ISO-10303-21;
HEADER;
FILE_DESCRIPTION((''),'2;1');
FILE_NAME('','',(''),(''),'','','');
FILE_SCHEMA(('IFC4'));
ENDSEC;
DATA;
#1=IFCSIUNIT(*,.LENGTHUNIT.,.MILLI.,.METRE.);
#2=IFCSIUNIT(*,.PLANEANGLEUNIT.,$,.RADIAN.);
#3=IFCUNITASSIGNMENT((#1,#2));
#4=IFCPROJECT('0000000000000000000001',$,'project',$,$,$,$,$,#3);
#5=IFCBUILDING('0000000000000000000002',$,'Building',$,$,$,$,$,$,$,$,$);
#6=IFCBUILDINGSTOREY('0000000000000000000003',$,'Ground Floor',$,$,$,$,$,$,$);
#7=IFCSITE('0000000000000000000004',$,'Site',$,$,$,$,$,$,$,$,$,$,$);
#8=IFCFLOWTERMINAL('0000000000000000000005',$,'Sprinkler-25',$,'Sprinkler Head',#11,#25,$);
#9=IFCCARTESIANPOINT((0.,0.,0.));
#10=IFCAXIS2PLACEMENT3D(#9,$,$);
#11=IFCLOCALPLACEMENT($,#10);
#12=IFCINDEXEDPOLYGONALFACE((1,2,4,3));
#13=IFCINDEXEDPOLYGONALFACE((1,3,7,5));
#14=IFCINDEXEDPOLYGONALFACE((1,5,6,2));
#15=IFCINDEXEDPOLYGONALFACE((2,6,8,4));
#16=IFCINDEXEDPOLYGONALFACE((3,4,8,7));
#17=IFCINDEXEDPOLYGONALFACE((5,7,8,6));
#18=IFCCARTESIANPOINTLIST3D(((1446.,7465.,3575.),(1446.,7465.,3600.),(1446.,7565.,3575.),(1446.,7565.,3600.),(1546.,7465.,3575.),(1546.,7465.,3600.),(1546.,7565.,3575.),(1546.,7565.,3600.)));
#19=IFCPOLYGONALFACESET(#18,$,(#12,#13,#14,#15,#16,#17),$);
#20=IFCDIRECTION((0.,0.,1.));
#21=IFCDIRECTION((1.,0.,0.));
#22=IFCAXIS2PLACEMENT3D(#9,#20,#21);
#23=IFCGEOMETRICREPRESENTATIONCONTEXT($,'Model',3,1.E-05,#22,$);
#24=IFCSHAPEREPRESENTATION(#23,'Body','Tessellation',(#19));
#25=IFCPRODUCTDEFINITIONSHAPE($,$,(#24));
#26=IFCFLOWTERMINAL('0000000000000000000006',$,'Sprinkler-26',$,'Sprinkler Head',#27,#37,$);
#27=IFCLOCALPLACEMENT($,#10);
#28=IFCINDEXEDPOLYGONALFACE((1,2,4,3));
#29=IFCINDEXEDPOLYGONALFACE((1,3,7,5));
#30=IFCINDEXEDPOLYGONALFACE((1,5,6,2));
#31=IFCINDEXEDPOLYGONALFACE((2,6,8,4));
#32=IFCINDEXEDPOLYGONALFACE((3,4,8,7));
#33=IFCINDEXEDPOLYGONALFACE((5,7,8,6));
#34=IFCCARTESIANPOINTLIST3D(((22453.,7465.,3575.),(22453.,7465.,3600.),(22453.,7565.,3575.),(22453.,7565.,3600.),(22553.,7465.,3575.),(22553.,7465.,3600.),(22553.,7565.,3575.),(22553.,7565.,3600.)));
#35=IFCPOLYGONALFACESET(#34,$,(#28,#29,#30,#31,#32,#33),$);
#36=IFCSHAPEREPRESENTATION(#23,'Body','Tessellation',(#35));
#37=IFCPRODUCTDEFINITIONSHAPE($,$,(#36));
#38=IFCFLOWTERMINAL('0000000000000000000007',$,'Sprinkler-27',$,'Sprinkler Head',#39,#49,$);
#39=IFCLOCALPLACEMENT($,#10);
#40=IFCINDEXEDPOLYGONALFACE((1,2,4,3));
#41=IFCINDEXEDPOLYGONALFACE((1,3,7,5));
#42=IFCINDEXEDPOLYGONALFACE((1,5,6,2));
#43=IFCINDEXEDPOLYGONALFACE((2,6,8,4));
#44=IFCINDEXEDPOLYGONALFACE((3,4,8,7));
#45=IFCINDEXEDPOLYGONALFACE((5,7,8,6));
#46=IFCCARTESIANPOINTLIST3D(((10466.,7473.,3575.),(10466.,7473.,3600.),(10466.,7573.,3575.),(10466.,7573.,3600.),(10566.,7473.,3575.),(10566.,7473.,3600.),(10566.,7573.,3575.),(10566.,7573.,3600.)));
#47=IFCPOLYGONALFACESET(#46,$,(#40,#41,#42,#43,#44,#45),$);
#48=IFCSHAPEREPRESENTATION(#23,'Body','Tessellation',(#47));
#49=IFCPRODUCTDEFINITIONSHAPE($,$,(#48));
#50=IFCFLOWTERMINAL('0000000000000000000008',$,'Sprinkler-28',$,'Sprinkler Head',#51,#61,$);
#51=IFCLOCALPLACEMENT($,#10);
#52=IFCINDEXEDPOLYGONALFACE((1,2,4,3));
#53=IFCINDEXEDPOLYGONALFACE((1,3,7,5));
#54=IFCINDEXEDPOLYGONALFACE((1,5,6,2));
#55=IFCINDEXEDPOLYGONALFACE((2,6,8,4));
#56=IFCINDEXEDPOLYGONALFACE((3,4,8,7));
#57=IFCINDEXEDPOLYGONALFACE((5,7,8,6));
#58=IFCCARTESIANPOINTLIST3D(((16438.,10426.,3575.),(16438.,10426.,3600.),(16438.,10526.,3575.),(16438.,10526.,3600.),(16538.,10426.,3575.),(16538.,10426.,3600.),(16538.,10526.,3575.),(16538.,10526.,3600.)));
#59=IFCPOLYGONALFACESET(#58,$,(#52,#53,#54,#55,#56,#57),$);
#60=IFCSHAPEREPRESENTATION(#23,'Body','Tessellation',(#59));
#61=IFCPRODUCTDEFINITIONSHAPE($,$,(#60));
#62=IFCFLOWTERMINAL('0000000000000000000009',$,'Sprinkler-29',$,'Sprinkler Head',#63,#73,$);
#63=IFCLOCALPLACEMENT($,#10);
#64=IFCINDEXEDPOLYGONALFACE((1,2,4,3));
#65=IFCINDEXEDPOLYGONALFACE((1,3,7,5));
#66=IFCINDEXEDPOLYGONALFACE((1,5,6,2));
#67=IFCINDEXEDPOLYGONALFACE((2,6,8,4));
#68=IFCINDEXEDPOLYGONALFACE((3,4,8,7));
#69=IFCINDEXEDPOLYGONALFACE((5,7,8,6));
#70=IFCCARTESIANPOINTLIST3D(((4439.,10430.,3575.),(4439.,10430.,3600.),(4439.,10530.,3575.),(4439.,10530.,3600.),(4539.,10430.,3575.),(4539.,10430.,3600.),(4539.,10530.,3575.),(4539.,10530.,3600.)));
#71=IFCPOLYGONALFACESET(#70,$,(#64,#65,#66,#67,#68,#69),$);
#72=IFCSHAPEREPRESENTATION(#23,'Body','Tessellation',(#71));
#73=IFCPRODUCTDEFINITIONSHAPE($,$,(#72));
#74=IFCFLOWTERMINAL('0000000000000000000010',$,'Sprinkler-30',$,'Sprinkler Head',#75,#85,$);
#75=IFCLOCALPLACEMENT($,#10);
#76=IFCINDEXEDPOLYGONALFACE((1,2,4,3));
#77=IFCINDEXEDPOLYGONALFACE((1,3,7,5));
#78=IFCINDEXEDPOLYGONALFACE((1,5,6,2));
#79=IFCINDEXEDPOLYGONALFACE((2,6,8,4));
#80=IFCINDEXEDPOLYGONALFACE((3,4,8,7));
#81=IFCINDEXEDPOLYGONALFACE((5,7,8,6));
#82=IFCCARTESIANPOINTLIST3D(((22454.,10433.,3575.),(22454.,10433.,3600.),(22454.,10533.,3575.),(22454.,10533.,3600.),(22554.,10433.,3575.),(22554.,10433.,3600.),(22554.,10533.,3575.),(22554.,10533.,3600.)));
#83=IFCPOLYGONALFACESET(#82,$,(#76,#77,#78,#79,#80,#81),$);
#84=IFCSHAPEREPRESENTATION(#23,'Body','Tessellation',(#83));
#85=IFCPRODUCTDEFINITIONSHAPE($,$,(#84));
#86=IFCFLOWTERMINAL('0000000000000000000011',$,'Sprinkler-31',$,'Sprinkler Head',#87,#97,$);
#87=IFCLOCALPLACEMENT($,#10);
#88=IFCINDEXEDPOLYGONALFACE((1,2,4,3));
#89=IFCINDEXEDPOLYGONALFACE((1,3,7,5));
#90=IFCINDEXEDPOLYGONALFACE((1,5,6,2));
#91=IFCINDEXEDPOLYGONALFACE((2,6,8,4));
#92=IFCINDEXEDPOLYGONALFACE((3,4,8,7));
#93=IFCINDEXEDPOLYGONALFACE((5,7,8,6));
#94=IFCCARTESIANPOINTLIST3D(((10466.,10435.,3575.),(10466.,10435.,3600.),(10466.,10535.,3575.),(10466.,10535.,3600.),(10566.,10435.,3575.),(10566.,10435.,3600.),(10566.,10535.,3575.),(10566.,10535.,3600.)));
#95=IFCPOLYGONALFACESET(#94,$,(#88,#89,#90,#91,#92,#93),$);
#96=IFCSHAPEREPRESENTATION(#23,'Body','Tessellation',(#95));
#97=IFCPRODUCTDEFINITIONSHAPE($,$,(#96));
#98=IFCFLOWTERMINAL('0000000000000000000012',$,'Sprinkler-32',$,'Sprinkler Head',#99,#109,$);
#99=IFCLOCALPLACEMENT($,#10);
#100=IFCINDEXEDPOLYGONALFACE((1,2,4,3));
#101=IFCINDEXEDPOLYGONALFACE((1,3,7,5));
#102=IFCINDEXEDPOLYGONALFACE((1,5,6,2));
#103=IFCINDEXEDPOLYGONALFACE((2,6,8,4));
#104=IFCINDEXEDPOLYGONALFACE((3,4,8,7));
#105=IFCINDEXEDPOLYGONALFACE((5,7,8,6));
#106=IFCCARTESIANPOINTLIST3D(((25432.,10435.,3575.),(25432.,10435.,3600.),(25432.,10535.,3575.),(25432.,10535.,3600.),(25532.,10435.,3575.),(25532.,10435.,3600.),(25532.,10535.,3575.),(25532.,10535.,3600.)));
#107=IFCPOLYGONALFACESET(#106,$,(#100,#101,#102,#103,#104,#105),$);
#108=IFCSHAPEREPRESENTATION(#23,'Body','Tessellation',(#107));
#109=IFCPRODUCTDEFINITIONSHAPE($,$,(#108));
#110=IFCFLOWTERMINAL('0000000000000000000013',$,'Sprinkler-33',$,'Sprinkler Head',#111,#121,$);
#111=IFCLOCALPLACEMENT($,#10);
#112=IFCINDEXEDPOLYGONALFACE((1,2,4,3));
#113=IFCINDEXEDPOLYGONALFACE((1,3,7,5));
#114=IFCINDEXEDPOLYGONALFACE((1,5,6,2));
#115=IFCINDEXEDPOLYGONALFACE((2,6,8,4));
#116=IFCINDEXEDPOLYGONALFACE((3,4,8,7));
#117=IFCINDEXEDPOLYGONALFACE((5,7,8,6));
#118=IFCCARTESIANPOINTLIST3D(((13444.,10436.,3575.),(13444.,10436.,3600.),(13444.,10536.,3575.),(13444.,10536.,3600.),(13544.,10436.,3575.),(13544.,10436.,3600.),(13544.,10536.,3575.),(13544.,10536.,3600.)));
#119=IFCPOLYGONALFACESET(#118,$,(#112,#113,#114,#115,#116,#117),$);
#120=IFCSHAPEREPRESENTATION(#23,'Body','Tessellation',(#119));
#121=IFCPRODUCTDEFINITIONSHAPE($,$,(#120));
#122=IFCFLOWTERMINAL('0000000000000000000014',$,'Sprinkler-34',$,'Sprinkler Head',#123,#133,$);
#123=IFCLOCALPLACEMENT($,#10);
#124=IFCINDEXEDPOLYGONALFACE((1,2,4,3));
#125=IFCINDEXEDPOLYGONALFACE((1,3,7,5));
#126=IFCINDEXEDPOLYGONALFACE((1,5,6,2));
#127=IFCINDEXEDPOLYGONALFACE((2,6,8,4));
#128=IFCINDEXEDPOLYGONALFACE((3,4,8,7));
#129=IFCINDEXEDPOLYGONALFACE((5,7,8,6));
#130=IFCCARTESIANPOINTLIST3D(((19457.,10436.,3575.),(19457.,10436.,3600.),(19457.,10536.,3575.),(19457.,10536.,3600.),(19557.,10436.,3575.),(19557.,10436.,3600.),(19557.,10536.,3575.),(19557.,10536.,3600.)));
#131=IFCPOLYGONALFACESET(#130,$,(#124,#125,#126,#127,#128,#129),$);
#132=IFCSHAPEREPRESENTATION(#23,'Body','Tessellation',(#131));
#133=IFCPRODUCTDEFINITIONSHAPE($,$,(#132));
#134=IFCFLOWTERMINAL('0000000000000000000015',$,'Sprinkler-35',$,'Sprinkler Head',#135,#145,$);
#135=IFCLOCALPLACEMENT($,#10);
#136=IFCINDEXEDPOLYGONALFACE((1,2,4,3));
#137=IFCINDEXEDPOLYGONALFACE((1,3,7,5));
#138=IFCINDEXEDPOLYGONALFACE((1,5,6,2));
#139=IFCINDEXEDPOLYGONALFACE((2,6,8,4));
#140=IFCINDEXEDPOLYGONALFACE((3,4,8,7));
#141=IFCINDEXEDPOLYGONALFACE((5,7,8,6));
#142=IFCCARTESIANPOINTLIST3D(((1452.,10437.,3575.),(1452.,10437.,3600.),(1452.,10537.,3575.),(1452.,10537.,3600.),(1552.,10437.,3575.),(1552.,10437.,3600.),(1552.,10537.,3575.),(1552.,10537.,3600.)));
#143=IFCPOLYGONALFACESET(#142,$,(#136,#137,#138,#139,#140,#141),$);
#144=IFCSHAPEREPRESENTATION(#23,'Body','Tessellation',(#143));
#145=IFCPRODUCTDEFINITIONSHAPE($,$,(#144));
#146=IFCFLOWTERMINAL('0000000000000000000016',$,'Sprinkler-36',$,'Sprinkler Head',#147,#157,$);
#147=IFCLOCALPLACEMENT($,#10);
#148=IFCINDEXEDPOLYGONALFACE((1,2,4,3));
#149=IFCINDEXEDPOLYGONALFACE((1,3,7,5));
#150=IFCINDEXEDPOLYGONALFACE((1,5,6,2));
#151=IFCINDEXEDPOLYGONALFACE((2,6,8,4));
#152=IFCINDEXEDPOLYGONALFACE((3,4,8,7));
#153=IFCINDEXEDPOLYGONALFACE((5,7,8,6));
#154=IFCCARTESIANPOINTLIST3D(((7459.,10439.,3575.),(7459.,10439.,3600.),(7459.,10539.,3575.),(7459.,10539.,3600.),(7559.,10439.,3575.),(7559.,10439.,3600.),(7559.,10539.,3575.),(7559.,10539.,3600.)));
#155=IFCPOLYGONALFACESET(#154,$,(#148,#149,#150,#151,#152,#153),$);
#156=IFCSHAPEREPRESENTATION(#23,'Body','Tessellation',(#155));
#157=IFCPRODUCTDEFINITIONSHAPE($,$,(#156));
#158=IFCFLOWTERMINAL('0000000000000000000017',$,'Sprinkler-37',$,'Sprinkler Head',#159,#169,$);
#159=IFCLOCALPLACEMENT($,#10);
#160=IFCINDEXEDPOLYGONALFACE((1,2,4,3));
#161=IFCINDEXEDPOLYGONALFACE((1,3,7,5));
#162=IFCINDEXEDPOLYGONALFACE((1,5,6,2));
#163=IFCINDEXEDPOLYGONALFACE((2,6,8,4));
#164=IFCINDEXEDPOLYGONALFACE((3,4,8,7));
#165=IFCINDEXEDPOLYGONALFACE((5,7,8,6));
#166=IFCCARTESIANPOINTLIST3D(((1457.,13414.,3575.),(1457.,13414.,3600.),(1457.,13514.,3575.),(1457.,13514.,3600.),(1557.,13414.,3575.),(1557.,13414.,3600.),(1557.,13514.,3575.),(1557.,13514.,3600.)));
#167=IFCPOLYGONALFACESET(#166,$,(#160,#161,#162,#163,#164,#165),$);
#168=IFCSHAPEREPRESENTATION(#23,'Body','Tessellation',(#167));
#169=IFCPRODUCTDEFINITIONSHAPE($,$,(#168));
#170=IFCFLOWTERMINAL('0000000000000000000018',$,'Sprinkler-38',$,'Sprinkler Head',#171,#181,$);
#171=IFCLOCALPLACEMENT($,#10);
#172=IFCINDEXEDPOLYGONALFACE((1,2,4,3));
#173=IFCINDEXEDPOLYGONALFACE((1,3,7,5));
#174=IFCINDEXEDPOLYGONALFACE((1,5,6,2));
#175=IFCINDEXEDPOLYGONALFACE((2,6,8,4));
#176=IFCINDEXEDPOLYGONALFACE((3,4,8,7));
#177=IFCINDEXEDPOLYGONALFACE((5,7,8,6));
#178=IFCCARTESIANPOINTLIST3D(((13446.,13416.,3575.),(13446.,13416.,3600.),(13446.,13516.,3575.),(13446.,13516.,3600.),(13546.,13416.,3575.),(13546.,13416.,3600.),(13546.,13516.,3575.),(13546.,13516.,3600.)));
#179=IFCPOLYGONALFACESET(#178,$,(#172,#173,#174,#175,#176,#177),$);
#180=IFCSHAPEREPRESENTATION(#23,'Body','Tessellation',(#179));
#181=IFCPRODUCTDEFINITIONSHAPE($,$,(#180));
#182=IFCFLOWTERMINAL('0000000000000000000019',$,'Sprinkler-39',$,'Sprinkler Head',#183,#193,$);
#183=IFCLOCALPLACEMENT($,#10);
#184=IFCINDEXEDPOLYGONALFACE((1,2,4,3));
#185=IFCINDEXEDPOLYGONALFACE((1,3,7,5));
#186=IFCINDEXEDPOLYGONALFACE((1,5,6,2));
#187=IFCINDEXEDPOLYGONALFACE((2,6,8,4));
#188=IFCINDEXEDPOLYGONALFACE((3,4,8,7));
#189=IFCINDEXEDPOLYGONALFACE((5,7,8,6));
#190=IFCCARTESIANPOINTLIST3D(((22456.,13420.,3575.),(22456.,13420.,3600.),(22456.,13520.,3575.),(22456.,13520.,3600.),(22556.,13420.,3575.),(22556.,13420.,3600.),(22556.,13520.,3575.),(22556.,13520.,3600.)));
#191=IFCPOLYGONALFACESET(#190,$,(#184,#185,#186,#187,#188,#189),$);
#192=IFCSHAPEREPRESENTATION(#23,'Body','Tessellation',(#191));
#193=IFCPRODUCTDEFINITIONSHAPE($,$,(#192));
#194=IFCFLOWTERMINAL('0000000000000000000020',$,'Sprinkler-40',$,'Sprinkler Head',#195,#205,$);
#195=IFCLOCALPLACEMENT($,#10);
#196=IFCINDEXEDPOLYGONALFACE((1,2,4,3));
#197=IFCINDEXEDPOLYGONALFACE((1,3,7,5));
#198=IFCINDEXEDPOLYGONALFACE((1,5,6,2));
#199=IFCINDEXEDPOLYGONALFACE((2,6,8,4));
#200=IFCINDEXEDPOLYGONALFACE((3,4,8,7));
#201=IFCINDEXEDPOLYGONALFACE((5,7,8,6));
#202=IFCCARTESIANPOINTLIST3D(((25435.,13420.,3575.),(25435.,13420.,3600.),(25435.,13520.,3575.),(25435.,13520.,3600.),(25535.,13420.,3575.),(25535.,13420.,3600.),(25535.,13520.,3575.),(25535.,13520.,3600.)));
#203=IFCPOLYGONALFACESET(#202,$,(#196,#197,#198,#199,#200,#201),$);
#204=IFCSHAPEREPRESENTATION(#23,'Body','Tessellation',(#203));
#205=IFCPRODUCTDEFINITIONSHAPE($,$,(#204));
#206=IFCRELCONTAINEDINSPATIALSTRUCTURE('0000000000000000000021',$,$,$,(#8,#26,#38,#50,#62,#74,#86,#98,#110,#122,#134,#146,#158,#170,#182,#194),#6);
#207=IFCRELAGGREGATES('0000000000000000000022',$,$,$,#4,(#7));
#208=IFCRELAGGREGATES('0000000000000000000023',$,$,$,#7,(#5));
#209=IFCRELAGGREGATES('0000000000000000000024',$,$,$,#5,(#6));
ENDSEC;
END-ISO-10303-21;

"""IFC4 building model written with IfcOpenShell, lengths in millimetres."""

from ifc_helpers import new_model, si_unit, frame, origin_with_axes, place, context, project, spatial, rectangle, extrude, element, save


model = new_model("IFC4")

# Units and contexts
model_context = context("Model", 3, precision=1e-05, world=origin_with_axes())
ifc_project = project(units=[si_unit("LENGTHUNIT", "METRE", prefix="MILLI"), si_unit("PLANEANGLEUNIT", "RADIAN")])

# Site, building, storey
site = spatial("IfcSite", under=ifc_project, Name="Site")
building = spatial("IfcBuilding", under=site, Name="Building")
storey = spatial("IfcBuildingStorey", under=building, Name="Ground Floor")

# Flow terminals
flow_terminal_1_placement = place(None, origin_with_axes())
element("IfcFlowTerminal", 1, at=flow_terminal_1_placement, inside=storey, Name="Sprinkler-25", ObjectType="Sprinkler Head", context=model_context, shape_type="SweptSolid", body=[
    extrude(rectangle(XDim=100.0, YDim=100.0), frame((1496.0, 7515.0, 3575.0), z_axis=(0.0, 0.0, 1.0), x_axis=(1.0, 0.0, 0.0)), (0.0, 0.0, 1.0), 25.0),
])
flow_terminal_2_placement = place(None, origin_with_axes())
element("IfcFlowTerminal", 2, at=flow_terminal_2_placement, inside=storey, Name="Sprinkler-26", ObjectType="Sprinkler Head", context=model_context, shape_type="SweptSolid", body=[
    extrude(rectangle(XDim=100.0, YDim=100.0), frame((22503.0, 7515.0, 3575.0), z_axis=(0.0, 0.0, 1.0), x_axis=(1.0, 0.0, 0.0)), (0.0, 0.0, 1.0), 25.0),
])
flow_terminal_3_placement = place(None, origin_with_axes())
element("IfcFlowTerminal", 3, at=flow_terminal_3_placement, inside=storey, Name="Sprinkler-27", ObjectType="Sprinkler Head", context=model_context, shape_type="SweptSolid", body=[
    extrude(rectangle(XDim=100.0, YDim=100.0), frame((10516.0, 7523.0, 3575.0), z_axis=(0.0, 0.0, 1.0), x_axis=(1.0, 0.0, 0.0)), (0.0, 0.0, 1.0), 25.0),
])
flow_terminal_4_placement = place(None, origin_with_axes())
element("IfcFlowTerminal", 4, at=flow_terminal_4_placement, inside=storey, Name="Sprinkler-28", ObjectType="Sprinkler Head", context=model_context, shape_type="SweptSolid", body=[
    extrude(rectangle(XDim=100.0, YDim=100.0), frame((16488.0, 10476.0, 3575.0), z_axis=(0.0, 0.0, 1.0), x_axis=(1.0, 0.0, 0.0)), (0.0, 0.0, 1.0), 25.0),
])
flow_terminal_5_placement = place(None, origin_with_axes())
element("IfcFlowTerminal", 5, at=flow_terminal_5_placement, inside=storey, Name="Sprinkler-29", ObjectType="Sprinkler Head", context=model_context, shape_type="SweptSolid", body=[
    extrude(rectangle(XDim=100.0, YDim=100.0), frame((4489.0, 10480.0, 3575.0), z_axis=(0.0, 0.0, 1.0), x_axis=(1.0, 0.0, 0.0)), (0.0, 0.0, 1.0), 25.0),
])
flow_terminal_6_placement = place(None, origin_with_axes())
element("IfcFlowTerminal", 6, at=flow_terminal_6_placement, inside=storey, Name="Sprinkler-30", ObjectType="Sprinkler Head", context=model_context, shape_type="SweptSolid", body=[
    extrude(rectangle(XDim=100.0, YDim=100.0), frame((22504.0, 10483.0, 3575.0), z_axis=(0.0, 0.0, 1.0), x_axis=(1.0, 0.0, 0.0)), (0.0, 0.0, 1.0), 25.0),
])
flow_terminal_7_placement = place(None, origin_with_axes())
element("IfcFlowTerminal", 7, at=flow_terminal_7_placement, inside=storey, Name="Sprinkler-31", ObjectType="Sprinkler Head", context=model_context, shape_type="SweptSolid", body=[
    extrude(rectangle(XDim=100.0, YDim=100.0), frame((10516.0, 10485.0, 3575.0), z_axis=(0.0, 0.0, 1.0), x_axis=(1.0, 0.0, 0.0)), (0.0, 0.0, 1.0), 25.0),
])
flow_terminal_8_placement = place(None, origin_with_axes())
element("IfcFlowTerminal", 8, at=flow_terminal_8_placement, inside=storey, Name="Sprinkler-32", ObjectType="Sprinkler Head", context=model_context, shape_type="SweptSolid", body=[
    extrude(rectangle(XDim=100.0, YDim=100.0), frame((25482.0, 10485.0, 3575.0), z_axis=(0.0, 0.0, 1.0), x_axis=(1.0, 0.0, 0.0)), (0.0, 0.0, 1.0), 25.0),
])
flow_terminal_9_placement = place(None, origin_with_axes())
element("IfcFlowTerminal", 9, at=flow_terminal_9_placement, inside=storey, Name="Sprinkler-33", ObjectType="Sprinkler Head", context=model_context, shape_type="SweptSolid", body=[
    extrude(rectangle(XDim=100.0, YDim=100.0), frame((13494.0, 10486.0, 3575.0), z_axis=(0.0, 0.0, 1.0), x_axis=(1.0, 0.0, 0.0)), (0.0, 0.0, 1.0), 25.0),
])
flow_terminal_10_placement = place(None, origin_with_axes())
element("IfcFlowTerminal", 10, at=flow_terminal_10_placement, inside=storey, Name="Sprinkler-34", ObjectType="Sprinkler Head", context=model_context, shape_type="SweptSolid", body=[
    extrude(rectangle(XDim=100.0, YDim=100.0), frame((19507.0, 10486.0, 3575.0), z_axis=(0.0, 0.0, 1.0), x_axis=(1.0, 0.0, 0.0)), (0.0, 0.0, 1.0), 25.0),
])
flow_terminal_11_placement = place(None, origin_with_axes())
element("IfcFlowTerminal", 11, at=flow_terminal_11_placement, inside=storey, Name="Sprinkler-35", ObjectType="Sprinkler Head", context=model_context, shape_type="SweptSolid", body=[
    extrude(rectangle(XDim=100.0, YDim=100.0), frame((1502.0, 10487.0, 3575.0), z_axis=(0.0, 0.0, 1.0), x_axis=(1.0, 0.0, 0.0)), (0.0, 0.0, 1.0), 25.0),
])
flow_terminal_12_placement = place(None, origin_with_axes())
element("IfcFlowTerminal", 12, at=flow_terminal_12_placement, inside=storey, Name="Sprinkler-36", ObjectType="Sprinkler Head", context=model_context, shape_type="SweptSolid", body=[
    extrude(rectangle(XDim=100.0, YDim=100.0), frame((7509.0, 10489.0, 3575.0), z_axis=(0.0, 0.0, 1.0), x_axis=(1.0, 0.0, 0.0)), (0.0, 0.0, 1.0), 25.0),
])
flow_terminal_13_placement = place(None, origin_with_axes())
element("IfcFlowTerminal", 13, at=flow_terminal_13_placement, inside=storey, Name="Sprinkler-37", ObjectType="Sprinkler Head", context=model_context, shape_type="SweptSolid", body=[
    extrude(rectangle(XDim=100.0, YDim=100.0), frame((1507.0, 13464.0, 3575.0), z_axis=(0.0, 0.0, 1.0), x_axis=(1.0, 0.0, 0.0)), (0.0, 0.0, 1.0), 25.0),
])
flow_terminal_14_placement = place(None, origin_with_axes())
element("IfcFlowTerminal", 14, at=flow_terminal_14_placement, inside=storey, Name="Sprinkler-38", ObjectType="Sprinkler Head", context=model_context, shape_type="SweptSolid", body=[
    extrude(rectangle(XDim=100.0, YDim=100.0), frame((13496.0, 13466.0, 3575.0), z_axis=(0.0, 0.0, 1.0), x_axis=(1.0, 0.0, 0.0)), (0.0, 0.0, 1.0), 25.0),
])
flow_terminal_15_placement = place(None, origin_with_axes())
element("IfcFlowTerminal", 15, at=flow_terminal_15_placement, inside=storey, Name="Sprinkler-39", ObjectType="Sprinkler Head", context=model_context, shape_type="SweptSolid", body=[
    extrude(rectangle(XDim=100.0, YDim=100.0), frame((22506.0, 13470.0, 3575.0), z_axis=(0.0, 0.0, 1.0), x_axis=(1.0, 0.0, 0.0)), (0.0, 0.0, 1.0), 25.0),
])
flow_terminal_16_placement = place(None, origin_with_axes())
element("IfcFlowTerminal", 16, at=flow_terminal_16_placement, inside=storey, Name="Sprinkler-40", ObjectType="Sprinkler Head", context=model_context, shape_type="SweptSolid", body=[
    extrude(rectangle(XDim=100.0, YDim=100.0), frame((25485.0, 13470.0, 3575.0), z_axis=(0.0, 0.0, 1.0), x_axis=(1.0, 0.0, 0.0)), (0.0, 0.0, 1.0), 25.0),
])

save(model, "model.ifc")
